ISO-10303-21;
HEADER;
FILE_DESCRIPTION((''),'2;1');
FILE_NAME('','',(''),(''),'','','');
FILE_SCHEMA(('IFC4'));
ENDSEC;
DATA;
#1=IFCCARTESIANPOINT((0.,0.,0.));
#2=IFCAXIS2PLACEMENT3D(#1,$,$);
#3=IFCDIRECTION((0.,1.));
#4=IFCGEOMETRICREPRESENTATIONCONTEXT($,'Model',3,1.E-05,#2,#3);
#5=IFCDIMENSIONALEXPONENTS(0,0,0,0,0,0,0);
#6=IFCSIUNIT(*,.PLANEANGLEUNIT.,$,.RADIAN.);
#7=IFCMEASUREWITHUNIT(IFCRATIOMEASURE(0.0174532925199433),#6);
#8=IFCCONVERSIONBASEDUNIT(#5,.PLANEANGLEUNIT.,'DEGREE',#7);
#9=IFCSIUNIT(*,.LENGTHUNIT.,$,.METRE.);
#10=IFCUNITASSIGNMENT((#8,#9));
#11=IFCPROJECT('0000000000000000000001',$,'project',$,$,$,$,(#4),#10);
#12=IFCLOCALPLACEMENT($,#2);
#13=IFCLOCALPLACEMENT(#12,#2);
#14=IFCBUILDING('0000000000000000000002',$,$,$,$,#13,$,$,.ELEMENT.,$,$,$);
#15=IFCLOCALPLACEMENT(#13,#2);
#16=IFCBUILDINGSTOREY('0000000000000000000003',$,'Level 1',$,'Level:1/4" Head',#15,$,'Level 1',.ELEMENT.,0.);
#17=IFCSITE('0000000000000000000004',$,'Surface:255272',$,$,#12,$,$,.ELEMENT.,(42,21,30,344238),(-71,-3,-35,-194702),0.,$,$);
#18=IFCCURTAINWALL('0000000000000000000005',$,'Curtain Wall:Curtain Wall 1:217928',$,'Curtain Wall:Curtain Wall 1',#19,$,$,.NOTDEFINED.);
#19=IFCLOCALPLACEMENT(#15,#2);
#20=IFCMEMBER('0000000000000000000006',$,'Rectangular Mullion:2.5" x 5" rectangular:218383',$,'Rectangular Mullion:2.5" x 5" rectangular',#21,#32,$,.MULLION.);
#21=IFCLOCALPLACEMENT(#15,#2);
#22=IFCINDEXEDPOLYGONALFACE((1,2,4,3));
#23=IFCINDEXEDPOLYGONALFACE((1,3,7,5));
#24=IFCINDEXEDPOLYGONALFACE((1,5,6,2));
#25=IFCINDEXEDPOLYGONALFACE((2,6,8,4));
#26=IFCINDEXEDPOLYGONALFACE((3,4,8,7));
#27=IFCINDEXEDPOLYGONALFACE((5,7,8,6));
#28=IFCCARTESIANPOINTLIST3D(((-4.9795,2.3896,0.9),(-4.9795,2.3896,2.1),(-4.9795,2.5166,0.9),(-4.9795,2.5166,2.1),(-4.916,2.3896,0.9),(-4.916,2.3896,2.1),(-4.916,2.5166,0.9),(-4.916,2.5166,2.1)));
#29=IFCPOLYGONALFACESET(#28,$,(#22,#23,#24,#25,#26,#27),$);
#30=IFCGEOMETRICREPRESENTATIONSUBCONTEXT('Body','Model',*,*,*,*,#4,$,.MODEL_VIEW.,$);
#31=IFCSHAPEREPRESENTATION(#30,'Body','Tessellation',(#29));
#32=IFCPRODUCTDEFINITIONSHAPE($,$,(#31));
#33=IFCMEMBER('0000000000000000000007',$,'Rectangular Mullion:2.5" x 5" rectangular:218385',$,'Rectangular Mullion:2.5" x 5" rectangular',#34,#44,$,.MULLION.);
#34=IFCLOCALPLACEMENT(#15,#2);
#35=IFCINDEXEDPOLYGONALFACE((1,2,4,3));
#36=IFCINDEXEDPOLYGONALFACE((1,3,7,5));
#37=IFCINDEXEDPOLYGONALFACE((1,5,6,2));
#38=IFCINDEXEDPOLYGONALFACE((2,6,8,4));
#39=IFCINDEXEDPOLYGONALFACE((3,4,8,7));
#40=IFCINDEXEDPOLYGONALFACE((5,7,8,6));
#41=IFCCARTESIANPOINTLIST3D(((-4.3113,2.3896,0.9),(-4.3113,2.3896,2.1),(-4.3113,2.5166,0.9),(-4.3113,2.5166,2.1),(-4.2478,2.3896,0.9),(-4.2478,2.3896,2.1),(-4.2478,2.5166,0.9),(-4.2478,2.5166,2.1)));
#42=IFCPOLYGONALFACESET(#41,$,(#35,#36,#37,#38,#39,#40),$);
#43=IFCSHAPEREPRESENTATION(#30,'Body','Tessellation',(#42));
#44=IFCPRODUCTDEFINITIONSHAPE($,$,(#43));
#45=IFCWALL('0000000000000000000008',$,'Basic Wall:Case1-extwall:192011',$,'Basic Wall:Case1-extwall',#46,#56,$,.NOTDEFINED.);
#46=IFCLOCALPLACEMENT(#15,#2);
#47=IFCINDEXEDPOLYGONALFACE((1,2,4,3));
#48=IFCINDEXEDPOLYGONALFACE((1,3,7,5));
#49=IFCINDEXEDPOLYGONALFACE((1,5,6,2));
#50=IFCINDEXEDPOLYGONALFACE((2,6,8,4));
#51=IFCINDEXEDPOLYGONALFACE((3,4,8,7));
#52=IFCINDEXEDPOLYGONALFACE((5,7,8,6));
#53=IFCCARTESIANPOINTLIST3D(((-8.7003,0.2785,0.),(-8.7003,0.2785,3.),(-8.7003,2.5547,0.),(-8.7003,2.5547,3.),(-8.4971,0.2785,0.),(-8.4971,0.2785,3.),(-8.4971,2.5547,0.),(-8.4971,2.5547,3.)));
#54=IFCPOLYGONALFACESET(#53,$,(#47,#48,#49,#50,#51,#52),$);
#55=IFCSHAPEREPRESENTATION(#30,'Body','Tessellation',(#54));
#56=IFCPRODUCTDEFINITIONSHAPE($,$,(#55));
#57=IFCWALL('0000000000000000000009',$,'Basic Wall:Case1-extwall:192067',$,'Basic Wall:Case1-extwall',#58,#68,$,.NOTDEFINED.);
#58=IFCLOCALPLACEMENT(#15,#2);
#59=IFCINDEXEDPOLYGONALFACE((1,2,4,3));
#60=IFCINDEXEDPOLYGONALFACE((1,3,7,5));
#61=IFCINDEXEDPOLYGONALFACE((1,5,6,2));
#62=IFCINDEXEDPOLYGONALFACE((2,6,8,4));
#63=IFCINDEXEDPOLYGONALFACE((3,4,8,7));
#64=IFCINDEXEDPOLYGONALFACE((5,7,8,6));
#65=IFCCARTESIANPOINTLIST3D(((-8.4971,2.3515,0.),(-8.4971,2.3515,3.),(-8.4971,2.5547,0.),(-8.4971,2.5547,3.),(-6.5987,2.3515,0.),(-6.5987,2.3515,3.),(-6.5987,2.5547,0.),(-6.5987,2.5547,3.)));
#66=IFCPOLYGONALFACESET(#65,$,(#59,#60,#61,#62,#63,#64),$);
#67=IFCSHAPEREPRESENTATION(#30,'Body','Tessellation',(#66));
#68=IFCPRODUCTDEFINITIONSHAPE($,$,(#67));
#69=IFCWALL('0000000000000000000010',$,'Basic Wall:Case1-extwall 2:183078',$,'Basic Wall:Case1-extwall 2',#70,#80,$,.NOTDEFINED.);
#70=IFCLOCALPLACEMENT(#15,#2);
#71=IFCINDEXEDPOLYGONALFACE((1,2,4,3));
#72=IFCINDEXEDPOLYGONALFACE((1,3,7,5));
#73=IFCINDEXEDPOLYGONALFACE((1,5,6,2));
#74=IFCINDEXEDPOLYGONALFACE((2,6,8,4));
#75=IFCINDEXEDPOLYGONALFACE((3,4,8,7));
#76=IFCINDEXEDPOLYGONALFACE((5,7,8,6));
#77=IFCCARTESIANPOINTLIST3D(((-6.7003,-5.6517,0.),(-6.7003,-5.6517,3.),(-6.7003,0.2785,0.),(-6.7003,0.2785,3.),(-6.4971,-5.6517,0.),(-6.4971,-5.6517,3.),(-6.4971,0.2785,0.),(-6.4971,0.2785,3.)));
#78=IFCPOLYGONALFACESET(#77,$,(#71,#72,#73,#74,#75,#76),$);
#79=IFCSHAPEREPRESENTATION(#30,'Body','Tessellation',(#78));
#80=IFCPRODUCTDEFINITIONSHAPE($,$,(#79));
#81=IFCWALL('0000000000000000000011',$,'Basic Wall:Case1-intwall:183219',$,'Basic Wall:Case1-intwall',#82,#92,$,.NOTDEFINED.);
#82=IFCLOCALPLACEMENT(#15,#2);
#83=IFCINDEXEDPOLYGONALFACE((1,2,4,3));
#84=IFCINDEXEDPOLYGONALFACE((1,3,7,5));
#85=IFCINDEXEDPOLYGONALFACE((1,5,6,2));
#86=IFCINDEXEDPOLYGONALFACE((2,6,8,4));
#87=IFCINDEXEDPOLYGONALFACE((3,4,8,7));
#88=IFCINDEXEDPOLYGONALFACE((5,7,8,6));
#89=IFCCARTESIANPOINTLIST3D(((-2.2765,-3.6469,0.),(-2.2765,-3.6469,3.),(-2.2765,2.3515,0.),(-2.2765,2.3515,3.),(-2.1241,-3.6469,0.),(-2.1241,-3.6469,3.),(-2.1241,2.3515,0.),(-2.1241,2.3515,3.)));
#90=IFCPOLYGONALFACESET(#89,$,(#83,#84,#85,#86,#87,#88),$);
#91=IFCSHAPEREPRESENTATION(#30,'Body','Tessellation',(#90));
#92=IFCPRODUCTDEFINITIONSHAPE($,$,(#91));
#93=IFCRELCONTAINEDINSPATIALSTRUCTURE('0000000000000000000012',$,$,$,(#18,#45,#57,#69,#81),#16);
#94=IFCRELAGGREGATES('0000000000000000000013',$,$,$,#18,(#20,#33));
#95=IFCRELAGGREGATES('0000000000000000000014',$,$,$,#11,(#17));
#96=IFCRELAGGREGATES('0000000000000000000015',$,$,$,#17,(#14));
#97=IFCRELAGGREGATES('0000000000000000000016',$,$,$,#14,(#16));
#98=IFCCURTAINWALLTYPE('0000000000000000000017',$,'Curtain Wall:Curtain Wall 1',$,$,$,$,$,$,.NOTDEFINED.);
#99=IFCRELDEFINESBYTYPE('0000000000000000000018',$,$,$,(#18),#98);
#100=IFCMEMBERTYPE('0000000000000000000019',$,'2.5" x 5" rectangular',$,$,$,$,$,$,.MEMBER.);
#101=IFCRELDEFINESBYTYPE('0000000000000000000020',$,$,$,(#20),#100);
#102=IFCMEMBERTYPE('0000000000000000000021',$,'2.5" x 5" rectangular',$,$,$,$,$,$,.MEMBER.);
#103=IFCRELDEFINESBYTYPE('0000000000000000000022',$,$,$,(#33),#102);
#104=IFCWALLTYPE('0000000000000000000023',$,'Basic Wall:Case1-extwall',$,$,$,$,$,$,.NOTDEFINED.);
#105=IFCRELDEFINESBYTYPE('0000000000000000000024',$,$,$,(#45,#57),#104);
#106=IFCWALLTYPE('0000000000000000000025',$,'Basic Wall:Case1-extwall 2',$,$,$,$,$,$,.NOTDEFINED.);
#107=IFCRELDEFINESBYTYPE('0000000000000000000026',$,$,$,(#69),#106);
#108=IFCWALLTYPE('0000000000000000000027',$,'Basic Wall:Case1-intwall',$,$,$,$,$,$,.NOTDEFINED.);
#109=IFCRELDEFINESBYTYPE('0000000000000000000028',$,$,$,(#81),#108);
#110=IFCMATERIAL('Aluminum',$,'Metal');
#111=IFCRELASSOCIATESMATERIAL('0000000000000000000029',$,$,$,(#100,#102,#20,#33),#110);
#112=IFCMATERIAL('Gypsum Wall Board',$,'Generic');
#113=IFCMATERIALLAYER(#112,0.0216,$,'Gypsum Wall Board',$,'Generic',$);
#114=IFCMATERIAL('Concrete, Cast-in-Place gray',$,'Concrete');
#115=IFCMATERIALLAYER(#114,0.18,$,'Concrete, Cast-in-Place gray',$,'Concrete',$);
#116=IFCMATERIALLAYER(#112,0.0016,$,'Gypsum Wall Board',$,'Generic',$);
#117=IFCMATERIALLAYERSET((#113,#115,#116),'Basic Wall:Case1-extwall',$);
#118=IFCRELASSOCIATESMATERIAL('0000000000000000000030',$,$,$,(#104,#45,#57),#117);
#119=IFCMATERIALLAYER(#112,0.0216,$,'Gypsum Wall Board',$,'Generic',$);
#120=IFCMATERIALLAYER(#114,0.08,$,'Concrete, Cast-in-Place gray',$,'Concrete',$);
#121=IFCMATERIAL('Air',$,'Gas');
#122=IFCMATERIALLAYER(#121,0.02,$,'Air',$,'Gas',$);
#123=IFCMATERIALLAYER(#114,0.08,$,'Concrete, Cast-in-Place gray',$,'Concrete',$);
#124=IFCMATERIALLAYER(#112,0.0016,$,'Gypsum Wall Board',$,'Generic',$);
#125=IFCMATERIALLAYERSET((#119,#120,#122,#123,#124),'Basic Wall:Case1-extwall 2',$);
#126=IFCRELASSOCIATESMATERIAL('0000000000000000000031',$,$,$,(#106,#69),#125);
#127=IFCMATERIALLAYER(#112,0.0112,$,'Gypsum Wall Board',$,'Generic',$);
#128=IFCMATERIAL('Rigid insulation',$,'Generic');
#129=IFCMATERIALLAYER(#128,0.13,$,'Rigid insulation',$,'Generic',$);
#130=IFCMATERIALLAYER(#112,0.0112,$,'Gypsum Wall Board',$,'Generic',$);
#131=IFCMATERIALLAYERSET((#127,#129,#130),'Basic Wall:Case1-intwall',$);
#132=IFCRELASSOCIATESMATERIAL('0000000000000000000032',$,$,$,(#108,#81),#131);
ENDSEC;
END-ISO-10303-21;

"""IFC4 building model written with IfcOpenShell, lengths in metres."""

from ifc_helpers import new_model, entity, si_unit, converted_unit, direction, frame, frame_2d, origin, origin_2d_with_axis, place, context, subcontext, project, spatial, polyline, rectangle, extrude, clip, bounded_halfspace, source, transform, mapped, material, layer, layer_set, layer_usage, material_profile, profile_set, profile_usage, type_object, type_shapes, element, aggregate, save


model = new_model("IFC4")

# Units and contexts
model_context = context("Model", 3, precision=1e-05, world=origin(), true_north=direction((0.0, 1.0)))
body_context = subcontext(model_context, "Body", "Model", "MODEL_VIEW")
ifc_project = project(units=[converted_unit("PLANEANGLEUNIT", "DEGREE", entity("IfcRatioMeasure", 0.0174532925199433), si_unit("PLANEANGLEUNIT", "RADIAN"), dimensions=[0, 0, 0, 0, 0, 0, 0]), si_unit("LENGTHUNIT", "METRE")], contexts=[model_context])

# Site, building, storey
site_placement = place(None, origin())
site = spatial("IfcSite", under=ifc_project, at=site_placement, Name="Surface:255272", CompositionType="ELEMENT", RefLatitude=(42, 21, 30, 344238), RefLongitude=(-71, -3, -35, -194702), RefElevation=0.0)
building_placement = place(site_placement, origin())
building = spatial("IfcBuilding", under=site, at=building_placement, CompositionType="ELEMENT")
storey_placement = place(building_placement, origin())
storey = spatial("IfcBuildingStorey", under=building, at=storey_placement, Name="Level 1", ObjectType="Level:1/4\" Head", LongName="Level 1", CompositionType="ELEMENT", Elevation=0.0)

# Curtain wall
curtain_wall_type = type_object("IfcCurtainWallType", Name="Curtain Wall:Curtain Wall 1", PredefinedType="NOTDEFINED")
ifc_material_1 = material(Name="Aluminum", Category="Metal")
ifc_material_profile_1 = material_profile(ifc_material_1, rectangle(XDim=0.127, YDim=0.0635, at=origin_2d_with_axis()), Name="2.5\" x 5\" rectangular")
ifc_profile_set_1 = profile_set([ifc_material_profile_1], Name="2.5\" x 5\" rectangular")
curtain_wall_1_placement = place(storey_placement, origin())
curtain_wall_1 = element("IfcCurtainWall", 1, at=curtain_wall_1_placement, inside=storey, type_object=curtain_wall_type, Name="Curtain Wall:Curtain Wall 1:217928", ObjectType="Curtain Wall:Curtain Wall 1", PredefinedType="NOTDEFINED")

# Members
ifc_profile_usage_1 = profile_usage(ifc_profile_set_1)
member_type_1 = type_object("IfcMemberType", Name="2.5\" x 5\" rectangular", PredefinedType="MEMBER", material=ifc_profile_set_1)
shared_shape_1 = source(origin(), body_context, "Body", "SweptSolid", [
    extrude(rectangle(XDim=0.127, YDim=0.0635, at=origin_2d_with_axis()), frame((0.0, 0.0, -1.2), z_axis=(0.0, 0.0, 1.0), x_axis=(0.0, -1.0, 0.0)), (0.0, 0.0, 1.0), 1.2),
])
type_shapes(member_type_1, [shared_shape_1])
member_1_placement = place(storey_placement, frame((-4.9478, 2.4531, 0.9), z_axis=(0.0, 0.0, -1.0), x_axis=(-1.0, 0.000007, 0.0)))
member_1 = element("IfcMember", 2, at=member_1_placement, type_object=member_type_1, material=ifc_profile_usage_1, Name="Rectangular Mullion:2.5\" x 5\" rectangular:218383", ObjectType="Rectangular Mullion:2.5\" x 5\" rectangular", PredefinedType="MULLION", context=body_context, shape_type="MappedRepresentation", body=[
    mapped(shared_shape_1, transform((0.0, 0.0, 0.0), scale=1.0)),
])
ifc_profile_usage_2 = profile_usage(ifc_profile_set_1)
member_type_2 = type_object("IfcMemberType", Name="2.5\" x 5\" rectangular", PredefinedType="MEMBER", material=ifc_profile_set_1)
shared_shape_2 = source(origin(), body_context, "Body", "SweptSolid", [
    extrude(rectangle(XDim=0.127, YDim=0.0635, at=origin_2d_with_axis()), frame((-0.0318, 0.0, -1.2), z_axis=(0.0, 0.0, 1.0), x_axis=(0.0, -1.0, 0.0)), (0.0, 0.0, 1.0), 1.2),
])
type_shapes(member_type_2, [shared_shape_2])
member_2_placement = place(storey_placement, frame((-4.2478, 2.4531, 2.1)))
member_2 = element("IfcMember", 3, at=member_2_placement, type_object=member_type_2, material=ifc_profile_usage_2, Name="Rectangular Mullion:2.5\" x 5\" rectangular:218385", ObjectType="Rectangular Mullion:2.5\" x 5\" rectangular", PredefinedType="MULLION", context=body_context, shape_type="MappedRepresentation", body=[
    mapped(shared_shape_2, transform((0.0, 0.0, 0.0), scale=1.0)),
])

aggregate(curtain_wall_1, [member_1, member_2])

# Walls
ifc_material_2 = material(Name="Gypsum Wall Board", Category="Generic")
ifc_layer_1 = layer(ifc_material_2, 0.0216, Name="Gypsum Wall Board", Category="Generic")
ifc_material_3 = material(Name="Concrete, Cast-in-Place gray", Category="Concrete")
ifc_layer_2 = layer(ifc_material_3, 0.18, Name="Concrete, Cast-in-Place gray", Category="Concrete")
ifc_layer_3 = layer(ifc_material_2, 0.0016, Name="Gypsum Wall Board", Category="Generic")
ifc_layer_set_1 = layer_set([ifc_layer_1, ifc_layer_2, ifc_layer_3], Name="Basic Wall:Case1-extwall")
ifc_layer_usage_1 = layer_usage(ifc_layer_set_1, "AXIS2", "NEGATIVE", 0.1016)
wall_type_1 = type_object("IfcWallType", Name="Basic Wall:Case1-extwall", PredefinedType="NOTDEFINED", material=ifc_layer_set_1)
wall_1_placement = place(storey_placement, frame((-8.5987, 0.2785, 0.0), z_axis=(0.0, 0.0, 1.0), x_axis=(0.000007, 1.0, 0.0)))
element("IfcWall", 4, at=wall_1_placement, inside=storey, type_object=wall_type_1, material=ifc_layer_usage_1, Name="Basic Wall:Case1-extwall:192011", ObjectType="Basic Wall:Case1-extwall", PredefinedType="NOTDEFINED", context=body_context, shape_type="Clipping", body=[
    clip(extrude(rectangle(XDim=2.2762, YDim=0.2032, at=frame_2d((1.1381, 0.0), x_axis=(-1.0, 0.0))), origin(), (0.0, 0.0, 1.0), 3.0), bounded_halfspace(frame((0.0, -0.1016, 3.0), z_axis=(0.0, 0.0, -1.0), x_axis=(0.0, 1.0, 0.0)), True, frame((0.0, -0.1016, 3.0)), polyline([(0.0, 0.0), (2.073, 0.0), (2.2762, 0.0), (2.2762, 0.2032), (0.0, 0.2032), (0.0, 0.0)]))),
])
ifc_layer_usage_2 = layer_usage(ifc_layer_set_1, "AXIS2", "NEGATIVE", 0.1016)
wall_2_placement = place(storey_placement, frame((-8.4971, 2.4531, 0.0)))
element("IfcWall", 5, at=wall_2_placement, inside=storey, type_object=wall_type_1, material=ifc_layer_usage_2, Name="Basic Wall:Case1-extwall:192067", ObjectType="Basic Wall:Case1-extwall", PredefinedType="NOTDEFINED", context=body_context, shape_type="Clipping", body=[
    clip(extrude(rectangle(XDim=1.8984, YDim=0.2032, at=frame_2d((0.9492, 0.0), x_axis=(-1.0, 0.0))), origin(), (0.0, 0.0, 1.0), 3.0), bounded_halfspace(frame((0.0, -0.1016, 3.0), z_axis=(0.0, 0.0, -1.0), x_axis=(-1.0, 0.0, 0.0)), True, frame((0.0, -0.1016, 3.0)), polyline([(0.0, 0.0), (1.8984, 0.0), (1.8984, 0.2032), (1.7968, 0.2032), (0.0, 0.2032), (0.0, 0.0)]))),
])
ifc_layer_4 = layer(ifc_material_2, 0.0216, Name="Gypsum Wall Board", Category="Generic")
ifc_layer_5 = layer(ifc_material_3, 0.08, Name="Concrete, Cast-in-Place gray", Category="Concrete")
ifc_material_4 = material(Name="Air", Category="Gas")
ifc_layer_6 = layer(ifc_material_4, 0.02, Name="Air", Category="Gas")
ifc_layer_7 = layer(ifc_material_3, 0.08, Name="Concrete, Cast-in-Place gray", Category="Concrete")
ifc_layer_8 = layer(ifc_material_2, 0.0016, Name="Gypsum Wall Board", Category="Generic")
ifc_layer_set_2 = layer_set([ifc_layer_4, ifc_layer_5, ifc_layer_6, ifc_layer_7, ifc_layer_8], Name="Basic Wall:Case1-extwall 2")
ifc_layer_usage_3 = layer_usage(ifc_layer_set_2, "AXIS2", "NEGATIVE", 0.1016)
wall_type_2 = type_object("IfcWallType", Name="Basic Wall:Case1-extwall 2", PredefinedType="NOTDEFINED", material=ifc_layer_set_2)
wall_3_placement = place(storey_placement, frame((-6.5987, 0.2785, 0.0), z_axis=(0.0, 0.0, 1.0), x_axis=(-0.000007, -1.0, 0.0)))
element("IfcWall", 6, at=wall_3_placement, inside=storey, type_object=wall_type_2, material=ifc_layer_usage_3, Name="Basic Wall:Case1-extwall 2:183078", ObjectType="Basic Wall:Case1-extwall 2", PredefinedType="NOTDEFINED", context=body_context, shape_type="Clipping", body=[
    clip(extrude(rectangle(XDim=5.9302, YDim=0.2032, at=frame_2d((2.9651, 0.0), x_axis=(-1.0, 0.0))), origin(), (0.0, 0.0, 1.0), 3.0), bounded_halfspace(frame((0.0, -0.1016, 3.0), z_axis=(0.0, 0.0, -1.0), x_axis=(0.0, -1.0, 0.0)), True, frame((0.0, -0.1016, 3.0)), polyline([(0.0, 0.0), (0.2032, 0.0), (5.9302, 0.0), (5.9302, 0.2032), (5.727, 0.2032), (0.7778, 0.2032), (0.6254, 0.2032), (0.0, 0.2032), (0.0, 0.0)]))),
])
ifc_layer_9 = layer(ifc_material_2, 0.0112, Name="Gypsum Wall Board", Category="Generic")
ifc_material_5 = material(Name="Rigid insulation", Category="Generic")
ifc_layer_10 = layer(ifc_material_5, 0.13, Name="Rigid insulation", Category="Generic")
ifc_layer_11 = layer(ifc_material_2, 0.0112, Name="Gypsum Wall Board", Category="Generic")
ifc_layer_set_3 = layer_set([ifc_layer_9, ifc_layer_10, ifc_layer_11], Name="Basic Wall:Case1-intwall")
ifc_layer_usage_4 = layer_usage(ifc_layer_set_3, "AXIS2", "NEGATIVE", 0.0762)
wall_type_3 = type_object("IfcWallType", Name="Basic Wall:Case1-intwall", PredefinedType="NOTDEFINED", material=ifc_layer_set_3)
wall_4_placement = place(storey_placement, frame((-2.2003, 2.3515, 0.0), z_axis=(0.0, 0.0, 1.0), x_axis=(-0.000007, -1.0, 0.0)))
element("IfcWall", 7, at=wall_4_placement, inside=storey, type_object=wall_type_3, material=ifc_layer_usage_4, Name="Basic Wall:Case1-intwall:183219", ObjectType="Basic Wall:Case1-intwall", PredefinedType="NOTDEFINED", context=body_context, shape_type="Clipping", body=[
    clip(extrude(rectangle(XDim=5.9984, YDim=0.1524, at=frame_2d((2.9992, 0.0), x_axis=(-1.0, 0.0))), origin(), (0.0, 0.0, 1.0), 3.0), bounded_halfspace(frame((0.0, -0.0762, 3.0), z_axis=(0.0, 0.0, -1.0), x_axis=(0.0, -1.0, 0.0)), True, frame((0.0, -0.0762, 3.0)), polyline([(0.0, 0.0), (2.6984, 0.0), (2.8508, 0.0), (5.9984, 0.0), (5.9984, 0.1524), (3.4778, 0.1524), (3.3254, 0.1524), (0.0, 0.1524), (0.0, 0.0)]))),
])

save(model, "model.ifc")
